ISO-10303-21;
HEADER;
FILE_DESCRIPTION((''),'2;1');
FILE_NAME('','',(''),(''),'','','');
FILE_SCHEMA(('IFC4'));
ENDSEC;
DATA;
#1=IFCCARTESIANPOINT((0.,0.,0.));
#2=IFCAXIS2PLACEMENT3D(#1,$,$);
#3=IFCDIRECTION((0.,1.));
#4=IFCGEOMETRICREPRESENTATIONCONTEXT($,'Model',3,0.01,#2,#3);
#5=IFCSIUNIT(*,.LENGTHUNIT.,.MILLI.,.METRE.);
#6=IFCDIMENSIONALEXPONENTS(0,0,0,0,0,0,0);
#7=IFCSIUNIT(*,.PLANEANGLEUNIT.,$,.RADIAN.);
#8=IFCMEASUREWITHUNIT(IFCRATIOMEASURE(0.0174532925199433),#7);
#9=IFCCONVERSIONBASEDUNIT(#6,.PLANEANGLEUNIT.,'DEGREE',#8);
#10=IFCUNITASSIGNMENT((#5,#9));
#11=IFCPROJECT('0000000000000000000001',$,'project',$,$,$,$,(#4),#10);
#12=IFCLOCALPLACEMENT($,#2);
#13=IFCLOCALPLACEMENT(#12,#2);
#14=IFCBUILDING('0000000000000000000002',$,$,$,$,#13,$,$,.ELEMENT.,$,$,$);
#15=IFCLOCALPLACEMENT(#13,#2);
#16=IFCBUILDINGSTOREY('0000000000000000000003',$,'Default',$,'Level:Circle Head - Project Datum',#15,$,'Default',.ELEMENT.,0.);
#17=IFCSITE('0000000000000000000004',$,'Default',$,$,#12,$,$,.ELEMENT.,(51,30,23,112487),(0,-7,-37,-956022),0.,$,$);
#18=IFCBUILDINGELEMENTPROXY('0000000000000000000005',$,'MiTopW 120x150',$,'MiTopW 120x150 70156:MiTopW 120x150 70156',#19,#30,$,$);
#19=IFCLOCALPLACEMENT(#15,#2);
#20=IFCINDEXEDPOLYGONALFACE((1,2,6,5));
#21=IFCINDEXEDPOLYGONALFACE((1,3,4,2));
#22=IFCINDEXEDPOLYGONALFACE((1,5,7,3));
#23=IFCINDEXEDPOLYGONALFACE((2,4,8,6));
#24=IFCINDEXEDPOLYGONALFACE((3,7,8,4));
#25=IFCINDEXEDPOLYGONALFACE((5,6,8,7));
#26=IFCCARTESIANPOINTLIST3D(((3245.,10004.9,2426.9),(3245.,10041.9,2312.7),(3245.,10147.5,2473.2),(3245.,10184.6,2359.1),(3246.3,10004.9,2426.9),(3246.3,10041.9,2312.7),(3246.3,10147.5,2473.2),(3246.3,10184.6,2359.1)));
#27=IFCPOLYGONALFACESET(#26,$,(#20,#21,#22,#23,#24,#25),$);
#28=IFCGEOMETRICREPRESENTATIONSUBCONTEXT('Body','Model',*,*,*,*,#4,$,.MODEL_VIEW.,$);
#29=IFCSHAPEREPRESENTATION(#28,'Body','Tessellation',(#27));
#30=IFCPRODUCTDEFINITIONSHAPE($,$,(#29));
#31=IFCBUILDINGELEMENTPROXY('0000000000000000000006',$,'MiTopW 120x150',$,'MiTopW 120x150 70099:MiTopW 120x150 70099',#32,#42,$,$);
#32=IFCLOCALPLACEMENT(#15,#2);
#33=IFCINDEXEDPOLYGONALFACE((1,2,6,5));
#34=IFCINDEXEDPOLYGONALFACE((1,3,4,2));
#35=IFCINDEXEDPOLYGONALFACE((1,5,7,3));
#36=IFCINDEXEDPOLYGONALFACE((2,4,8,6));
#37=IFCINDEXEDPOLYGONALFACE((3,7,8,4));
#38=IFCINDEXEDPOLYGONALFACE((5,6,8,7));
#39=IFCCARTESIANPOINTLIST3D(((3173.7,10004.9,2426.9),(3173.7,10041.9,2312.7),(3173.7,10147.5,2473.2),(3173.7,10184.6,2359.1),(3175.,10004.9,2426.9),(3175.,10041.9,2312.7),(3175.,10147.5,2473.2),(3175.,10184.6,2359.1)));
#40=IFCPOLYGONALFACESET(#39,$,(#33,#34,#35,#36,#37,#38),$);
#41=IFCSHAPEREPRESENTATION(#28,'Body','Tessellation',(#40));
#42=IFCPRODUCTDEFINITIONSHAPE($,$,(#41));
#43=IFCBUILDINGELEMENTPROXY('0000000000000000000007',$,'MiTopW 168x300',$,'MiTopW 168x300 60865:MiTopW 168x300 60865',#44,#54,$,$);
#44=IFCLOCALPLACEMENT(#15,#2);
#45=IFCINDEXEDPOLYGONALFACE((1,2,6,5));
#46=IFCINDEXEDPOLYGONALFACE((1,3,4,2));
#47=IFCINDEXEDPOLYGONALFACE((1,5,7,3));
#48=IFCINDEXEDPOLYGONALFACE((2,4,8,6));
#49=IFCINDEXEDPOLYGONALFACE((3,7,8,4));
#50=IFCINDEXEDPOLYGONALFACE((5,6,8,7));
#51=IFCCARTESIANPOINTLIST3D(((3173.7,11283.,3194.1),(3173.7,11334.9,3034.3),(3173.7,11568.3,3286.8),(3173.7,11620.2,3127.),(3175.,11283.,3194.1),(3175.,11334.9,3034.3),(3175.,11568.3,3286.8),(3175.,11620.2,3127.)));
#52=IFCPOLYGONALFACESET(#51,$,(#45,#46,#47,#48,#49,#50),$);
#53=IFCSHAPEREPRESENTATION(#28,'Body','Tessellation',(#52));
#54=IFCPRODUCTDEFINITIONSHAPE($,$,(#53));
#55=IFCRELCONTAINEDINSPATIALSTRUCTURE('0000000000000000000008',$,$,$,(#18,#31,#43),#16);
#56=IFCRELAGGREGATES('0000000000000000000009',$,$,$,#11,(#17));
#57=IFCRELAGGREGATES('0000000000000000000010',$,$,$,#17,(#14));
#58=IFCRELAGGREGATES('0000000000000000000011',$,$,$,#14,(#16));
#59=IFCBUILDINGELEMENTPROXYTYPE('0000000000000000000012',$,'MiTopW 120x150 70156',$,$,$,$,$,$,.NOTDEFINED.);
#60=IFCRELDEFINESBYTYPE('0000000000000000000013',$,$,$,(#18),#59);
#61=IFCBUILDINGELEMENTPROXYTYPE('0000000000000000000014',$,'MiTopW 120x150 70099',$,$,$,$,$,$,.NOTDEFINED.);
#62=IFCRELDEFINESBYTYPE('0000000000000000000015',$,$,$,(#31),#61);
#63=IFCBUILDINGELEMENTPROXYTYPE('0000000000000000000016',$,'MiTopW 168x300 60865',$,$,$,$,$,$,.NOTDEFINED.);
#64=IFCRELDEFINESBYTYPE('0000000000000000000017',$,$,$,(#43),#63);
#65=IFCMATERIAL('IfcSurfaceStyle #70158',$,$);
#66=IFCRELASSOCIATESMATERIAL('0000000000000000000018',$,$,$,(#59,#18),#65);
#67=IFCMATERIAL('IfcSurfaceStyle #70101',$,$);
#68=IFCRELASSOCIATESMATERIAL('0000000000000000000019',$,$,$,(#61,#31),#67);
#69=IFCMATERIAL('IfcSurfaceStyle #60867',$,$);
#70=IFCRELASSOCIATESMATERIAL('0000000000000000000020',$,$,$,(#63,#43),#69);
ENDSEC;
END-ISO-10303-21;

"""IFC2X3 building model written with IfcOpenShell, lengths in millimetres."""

from ifc_helpers import new_model, entity, si_unit, converted_unit, direction, frame, origin, place, context, subcontext, project, spatial, polyline, outline, extrude, source, transform, mapped, material, type_object, type_shapes, element, save


model = new_model("IFC2X3")

# Units and contexts
model_context = context("Model", 3, precision=0.01, world=origin(), true_north=direction((0.0, 1.0)))
body_context = subcontext(model_context, "Body", "Model", "MODEL_VIEW")
ifc_project = project(units=[si_unit("LENGTHUNIT", "METRE", prefix="MILLI"), converted_unit("PLANEANGLEUNIT", "DEGREE", entity("IfcRatioMeasure", 0.0174532925199433), si_unit("PLANEANGLEUNIT", "RADIAN"), dimensions=[0, 0, 0, 0, 0, 0, 0])], contexts=[model_context])

# Site, building, storey
site_placement = place(None, origin())
site = spatial("IfcSite", under=ifc_project, at=site_placement, Name="Default", CompositionType="ELEMENT", RefLatitude=(51, 30, 23, 112487), RefLongitude=(0, -7, -37, -956022), RefElevation=0.0)
building_placement = place(site_placement, origin())
building = spatial("IfcBuilding", under=site, at=building_placement, CompositionType="ELEMENT")
storey_placement = place(building_placement, origin())
storey = spatial("IfcBuildingStorey", under=building, at=storey_placement, Name="Default", ObjectType="Level:Circle Head - Project Datum", LongName="Default", CompositionType="ELEMENT", Elevation=0.0)

# Building element proxies
ifc_material_1 = material(Name="IfcSurfaceStyle #70158")
building_element_proxy_type_1 = type_object("IfcBuildingElementProxyType", Name="MiTopW 120x150 70156", PredefinedType="NOTDEFINED", material=ifc_material_1)
shared_shape_1 = source(origin(), body_context, "Body", "SweptSolid", [
    extrude(outline(polyline([(-75.0, -60.0), (75.0, -60.0), (75.0, 60.0), (-75.0, 60.0), (-75.0, -60.0)])), frame((75.0, 60.0, 0.0), z_axis=(0.0, 0.0, 1.0), x_axis=(-1.0, 0.0, 0.0)), (0.0, 0.0, 1.0), 1.3),
])
type_shapes(building_element_proxy_type_1, [shared_shape_1])
proxy_1_placement = place(building_placement, frame((3246.3, 10004.9, 2426.9), z_axis=(-1.0, 0.0, 0.0), x_axis=(0.0, 0.951057, 0.309017)))
element("IfcBuildingElementProxy", 1, at=proxy_1_placement, inside=storey, type_object=building_element_proxy_type_1, material=ifc_material_1, Name="MiTopW 120x150", ObjectType="MiTopW 120x150 70156:MiTopW 120x150 70156", context=body_context, shape_type="MappedRepresentation", body=[
    mapped(shared_shape_1, transform((0.0, 0.0, 0.0), scale=1.0)),
])
ifc_material_2 = material(Name="IfcSurfaceStyle #70101")
building_element_proxy_type_2 = type_object("IfcBuildingElementProxyType", Name="MiTopW 120x150 70099", PredefinedType="NOTDEFINED", material=ifc_material_2)
shared_shape_2 = source(origin(), body_context, "Body", "SweptSolid", [
    extrude(outline(polyline([(-75.0, -60.0), (75.0, -60.0), (75.0, 60.0), (-75.0, 60.0), (-75.0, -60.0)])), frame((75.0, 60.0, 0.0), z_axis=(0.0, 0.0, 1.0), x_axis=(-1.0, 0.0, 0.0)), (0.0, 0.0, 1.0), 1.3),
])
type_shapes(building_element_proxy_type_2, [shared_shape_2])
proxy_2_placement = place(building_placement, frame((3175.0, 10004.9, 2426.9), z_axis=(-1.0, 0.0, 0.0), x_axis=(0.0, 0.951057, 0.309017)))
element("IfcBuildingElementProxy", 2, at=proxy_2_placement, inside=storey, type_object=building_element_proxy_type_2, material=ifc_material_2, Name="MiTopW 120x150", ObjectType="MiTopW 120x150 70099:MiTopW 120x150 70099", context=body_context, shape_type="MappedRepresentation", body=[
    mapped(shared_shape_2, transform((0.0, 0.0, 0.0), scale=1.0)),
])
ifc_material_3 = material(Name="IfcSurfaceStyle #60867")
building_element_proxy_type_3 = type_object("IfcBuildingElementProxyType", Name="MiTopW 168x300 60865", PredefinedType="NOTDEFINED", material=ifc_material_3)
shared_shape_3 = source(origin(), body_context, "Body", "SweptSolid", [
    extrude(outline(polyline([(-150.0, -84.0), (150.0, -84.0), (150.0, 84.0), (-150.0, 84.0), (-150.0, -84.0)])), frame((150.0, 84.0, 0.0), z_axis=(0.0, 0.0, 1.0), x_axis=(-1.0, 0.0, 0.0)), (0.0, 0.0, 1.0), 1.3),
])
type_shapes(building_element_proxy_type_3, [shared_shape_3])
proxy_3_placement = place(building_placement, frame((3175.0, 11283.0, 3194.1), z_axis=(-1.0, 0.0, 0.0), x_axis=(0.0, 0.951057, 0.309017)))
element("IfcBuildingElementProxy", 3, at=proxy_3_placement, inside=storey, type_object=building_element_proxy_type_3, material=ifc_material_3, Name="MiTopW 168x300", ObjectType="MiTopW 168x300 60865:MiTopW 168x300 60865", context=body_context, shape_type="MappedRepresentation", body=[
    mapped(shared_shape_3, transform((0.0, 0.0, 0.0), scale=1.0)),
])

save(model, "model.ifc")
